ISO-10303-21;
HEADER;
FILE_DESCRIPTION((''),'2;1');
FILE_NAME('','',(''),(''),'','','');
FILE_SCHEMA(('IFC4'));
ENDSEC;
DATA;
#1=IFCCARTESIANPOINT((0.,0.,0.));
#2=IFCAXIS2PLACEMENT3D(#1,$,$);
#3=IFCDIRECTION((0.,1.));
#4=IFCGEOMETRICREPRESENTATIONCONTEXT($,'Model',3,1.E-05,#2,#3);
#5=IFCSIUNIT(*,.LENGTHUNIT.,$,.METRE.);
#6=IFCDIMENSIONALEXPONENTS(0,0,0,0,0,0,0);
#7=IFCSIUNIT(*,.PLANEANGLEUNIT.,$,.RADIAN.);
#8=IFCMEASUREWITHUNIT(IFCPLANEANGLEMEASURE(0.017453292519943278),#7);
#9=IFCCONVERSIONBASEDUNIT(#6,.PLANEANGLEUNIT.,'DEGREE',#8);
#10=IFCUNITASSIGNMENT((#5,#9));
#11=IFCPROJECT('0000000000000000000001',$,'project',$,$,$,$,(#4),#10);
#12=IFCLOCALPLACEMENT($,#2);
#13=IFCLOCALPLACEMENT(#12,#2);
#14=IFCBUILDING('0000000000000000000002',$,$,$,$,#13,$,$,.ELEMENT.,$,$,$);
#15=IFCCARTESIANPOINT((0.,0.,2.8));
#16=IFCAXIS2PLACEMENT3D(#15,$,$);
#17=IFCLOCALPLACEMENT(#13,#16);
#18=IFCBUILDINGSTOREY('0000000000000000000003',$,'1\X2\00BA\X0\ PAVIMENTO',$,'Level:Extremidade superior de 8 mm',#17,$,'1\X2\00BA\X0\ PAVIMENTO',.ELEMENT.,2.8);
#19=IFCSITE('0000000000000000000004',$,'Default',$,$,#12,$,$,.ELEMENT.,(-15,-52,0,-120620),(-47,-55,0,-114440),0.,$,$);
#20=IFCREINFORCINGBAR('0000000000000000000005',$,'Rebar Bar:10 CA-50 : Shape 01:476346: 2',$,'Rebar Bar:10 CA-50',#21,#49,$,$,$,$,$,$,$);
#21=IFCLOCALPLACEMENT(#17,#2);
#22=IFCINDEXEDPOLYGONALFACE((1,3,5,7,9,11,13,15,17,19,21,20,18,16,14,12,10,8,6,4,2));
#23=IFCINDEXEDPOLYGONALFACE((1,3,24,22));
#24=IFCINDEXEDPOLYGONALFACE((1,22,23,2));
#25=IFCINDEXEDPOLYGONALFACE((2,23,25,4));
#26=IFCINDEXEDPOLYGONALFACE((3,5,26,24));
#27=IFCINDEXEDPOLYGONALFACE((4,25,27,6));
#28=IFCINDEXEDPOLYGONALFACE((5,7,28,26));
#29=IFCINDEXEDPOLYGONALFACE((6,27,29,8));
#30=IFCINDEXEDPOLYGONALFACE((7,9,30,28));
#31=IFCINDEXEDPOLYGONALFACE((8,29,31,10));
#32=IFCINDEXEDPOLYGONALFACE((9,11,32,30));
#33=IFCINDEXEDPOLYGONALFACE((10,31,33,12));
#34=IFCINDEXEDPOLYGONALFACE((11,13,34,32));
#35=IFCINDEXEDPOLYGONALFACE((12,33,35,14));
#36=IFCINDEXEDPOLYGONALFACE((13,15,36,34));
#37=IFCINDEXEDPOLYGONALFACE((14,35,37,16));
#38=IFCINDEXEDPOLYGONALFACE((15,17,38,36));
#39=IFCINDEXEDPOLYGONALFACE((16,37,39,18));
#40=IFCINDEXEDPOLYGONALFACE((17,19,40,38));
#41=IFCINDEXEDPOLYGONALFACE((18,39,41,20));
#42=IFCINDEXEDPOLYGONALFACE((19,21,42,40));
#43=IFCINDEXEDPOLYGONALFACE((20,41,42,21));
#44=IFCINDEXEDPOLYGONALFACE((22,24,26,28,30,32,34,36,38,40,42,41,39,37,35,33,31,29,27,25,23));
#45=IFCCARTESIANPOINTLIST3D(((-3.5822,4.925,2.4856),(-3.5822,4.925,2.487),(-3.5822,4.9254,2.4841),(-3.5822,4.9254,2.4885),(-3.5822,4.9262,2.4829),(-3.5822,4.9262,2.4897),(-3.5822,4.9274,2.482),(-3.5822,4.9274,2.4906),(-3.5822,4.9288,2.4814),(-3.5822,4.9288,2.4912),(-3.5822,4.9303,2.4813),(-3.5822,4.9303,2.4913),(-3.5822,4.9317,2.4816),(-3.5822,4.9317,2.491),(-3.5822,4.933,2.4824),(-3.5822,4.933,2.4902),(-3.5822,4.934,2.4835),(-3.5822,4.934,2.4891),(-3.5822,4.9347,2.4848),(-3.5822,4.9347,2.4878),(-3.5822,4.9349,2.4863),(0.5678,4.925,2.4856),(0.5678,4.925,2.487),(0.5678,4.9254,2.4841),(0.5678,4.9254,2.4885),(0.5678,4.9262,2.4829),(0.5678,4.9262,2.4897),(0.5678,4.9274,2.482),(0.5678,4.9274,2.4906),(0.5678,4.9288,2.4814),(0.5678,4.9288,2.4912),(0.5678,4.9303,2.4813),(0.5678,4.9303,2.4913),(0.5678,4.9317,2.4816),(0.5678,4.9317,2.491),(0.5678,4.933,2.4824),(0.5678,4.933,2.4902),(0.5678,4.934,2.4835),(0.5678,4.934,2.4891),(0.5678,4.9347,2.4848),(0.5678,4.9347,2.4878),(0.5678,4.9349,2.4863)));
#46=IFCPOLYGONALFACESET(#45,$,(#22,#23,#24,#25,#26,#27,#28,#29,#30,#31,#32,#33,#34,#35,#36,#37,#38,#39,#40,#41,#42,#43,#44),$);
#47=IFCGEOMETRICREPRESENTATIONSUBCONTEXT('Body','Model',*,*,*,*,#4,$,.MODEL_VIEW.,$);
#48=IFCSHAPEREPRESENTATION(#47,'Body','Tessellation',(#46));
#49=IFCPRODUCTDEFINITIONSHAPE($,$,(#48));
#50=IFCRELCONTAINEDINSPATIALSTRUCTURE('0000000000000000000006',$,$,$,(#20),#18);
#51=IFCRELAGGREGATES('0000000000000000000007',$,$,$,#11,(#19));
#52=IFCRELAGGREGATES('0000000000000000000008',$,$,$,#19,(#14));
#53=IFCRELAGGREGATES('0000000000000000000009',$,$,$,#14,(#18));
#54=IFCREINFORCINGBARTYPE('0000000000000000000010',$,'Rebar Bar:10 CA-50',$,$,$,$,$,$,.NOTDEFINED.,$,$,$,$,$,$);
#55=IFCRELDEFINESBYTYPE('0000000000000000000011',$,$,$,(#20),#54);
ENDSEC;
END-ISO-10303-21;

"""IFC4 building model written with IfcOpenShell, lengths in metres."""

from ifc_helpers import new_model, entity, si_unit, converted_unit, direction, frame, origin, place, context, subcontext, project, spatial, type_object, element, save


model = new_model("IFC4")

# Units and contexts
model_context = context("Model", 3, precision=1e-05, world=origin(), true_north=direction((0.0, 1.0)))
body_context = subcontext(model_context, "Body", "Model", "MODEL_VIEW")
ifc_project = project(units=[si_unit("LENGTHUNIT", "METRE"), converted_unit("PLANEANGLEUNIT", "DEGREE", entity("IfcPlaneAngleMeasure", 0.017453292519943278), si_unit("PLANEANGLEUNIT", "RADIAN"), dimensions=[0, 0, 0, 0, 0, 0, 0])], contexts=[model_context])

# Site, building, storey
site_placement = place(None, origin())
site = spatial("IfcSite", under=ifc_project, at=site_placement, Name="Default", CompositionType="ELEMENT", RefLatitude=(-15, -52, 0, -120620), RefLongitude=(-47, -55, 0, -114440), RefElevation=0.0)
building_placement = place(site_placement, origin())
building = spatial("IfcBuilding", under=site, at=building_placement, CompositionType="ELEMENT")
storey_placement = place(building_placement, frame((0.0, 0.0, 2.8)))
storey = spatial("IfcBuildingStorey", under=building, at=storey_placement, Name="1º PAVIMENTO", ObjectType="Level:Extremidade superior de 8 mm", LongName="1º PAVIMENTO", CompositionType="ELEMENT", Elevation=2.8)

# Reinforcing bar
reinforcing_bar_type = type_object("IfcReinforcingBarType", Name="Rebar Bar:10 CA-50", PredefinedType="NOTDEFINED")
reinforcing_bar_1_placement = place(storey_placement, origin())
element("IfcReinforcingBar", 1, at=reinforcing_bar_1_placement, inside=storey, type_object=reinforcing_bar_type, Name="Rebar Bar:10 CA-50 : Shape 01:476346: 2", ObjectType="Rebar Bar:10 CA-50", context=body_context, shape_type="AdvancedSweptSolid", body=[
    entity("IfcSweptDiskSolid", entity("IfcIndexedPolyCurve", entity("IfcCartesianPointList3D", [[-3.5822, 4.9299, 2.4863], [0.5678, 4.9299, 2.4863]]), None, False), 0.005, None, 0.0, 1.0),
])

save(model, "model.ifc")
